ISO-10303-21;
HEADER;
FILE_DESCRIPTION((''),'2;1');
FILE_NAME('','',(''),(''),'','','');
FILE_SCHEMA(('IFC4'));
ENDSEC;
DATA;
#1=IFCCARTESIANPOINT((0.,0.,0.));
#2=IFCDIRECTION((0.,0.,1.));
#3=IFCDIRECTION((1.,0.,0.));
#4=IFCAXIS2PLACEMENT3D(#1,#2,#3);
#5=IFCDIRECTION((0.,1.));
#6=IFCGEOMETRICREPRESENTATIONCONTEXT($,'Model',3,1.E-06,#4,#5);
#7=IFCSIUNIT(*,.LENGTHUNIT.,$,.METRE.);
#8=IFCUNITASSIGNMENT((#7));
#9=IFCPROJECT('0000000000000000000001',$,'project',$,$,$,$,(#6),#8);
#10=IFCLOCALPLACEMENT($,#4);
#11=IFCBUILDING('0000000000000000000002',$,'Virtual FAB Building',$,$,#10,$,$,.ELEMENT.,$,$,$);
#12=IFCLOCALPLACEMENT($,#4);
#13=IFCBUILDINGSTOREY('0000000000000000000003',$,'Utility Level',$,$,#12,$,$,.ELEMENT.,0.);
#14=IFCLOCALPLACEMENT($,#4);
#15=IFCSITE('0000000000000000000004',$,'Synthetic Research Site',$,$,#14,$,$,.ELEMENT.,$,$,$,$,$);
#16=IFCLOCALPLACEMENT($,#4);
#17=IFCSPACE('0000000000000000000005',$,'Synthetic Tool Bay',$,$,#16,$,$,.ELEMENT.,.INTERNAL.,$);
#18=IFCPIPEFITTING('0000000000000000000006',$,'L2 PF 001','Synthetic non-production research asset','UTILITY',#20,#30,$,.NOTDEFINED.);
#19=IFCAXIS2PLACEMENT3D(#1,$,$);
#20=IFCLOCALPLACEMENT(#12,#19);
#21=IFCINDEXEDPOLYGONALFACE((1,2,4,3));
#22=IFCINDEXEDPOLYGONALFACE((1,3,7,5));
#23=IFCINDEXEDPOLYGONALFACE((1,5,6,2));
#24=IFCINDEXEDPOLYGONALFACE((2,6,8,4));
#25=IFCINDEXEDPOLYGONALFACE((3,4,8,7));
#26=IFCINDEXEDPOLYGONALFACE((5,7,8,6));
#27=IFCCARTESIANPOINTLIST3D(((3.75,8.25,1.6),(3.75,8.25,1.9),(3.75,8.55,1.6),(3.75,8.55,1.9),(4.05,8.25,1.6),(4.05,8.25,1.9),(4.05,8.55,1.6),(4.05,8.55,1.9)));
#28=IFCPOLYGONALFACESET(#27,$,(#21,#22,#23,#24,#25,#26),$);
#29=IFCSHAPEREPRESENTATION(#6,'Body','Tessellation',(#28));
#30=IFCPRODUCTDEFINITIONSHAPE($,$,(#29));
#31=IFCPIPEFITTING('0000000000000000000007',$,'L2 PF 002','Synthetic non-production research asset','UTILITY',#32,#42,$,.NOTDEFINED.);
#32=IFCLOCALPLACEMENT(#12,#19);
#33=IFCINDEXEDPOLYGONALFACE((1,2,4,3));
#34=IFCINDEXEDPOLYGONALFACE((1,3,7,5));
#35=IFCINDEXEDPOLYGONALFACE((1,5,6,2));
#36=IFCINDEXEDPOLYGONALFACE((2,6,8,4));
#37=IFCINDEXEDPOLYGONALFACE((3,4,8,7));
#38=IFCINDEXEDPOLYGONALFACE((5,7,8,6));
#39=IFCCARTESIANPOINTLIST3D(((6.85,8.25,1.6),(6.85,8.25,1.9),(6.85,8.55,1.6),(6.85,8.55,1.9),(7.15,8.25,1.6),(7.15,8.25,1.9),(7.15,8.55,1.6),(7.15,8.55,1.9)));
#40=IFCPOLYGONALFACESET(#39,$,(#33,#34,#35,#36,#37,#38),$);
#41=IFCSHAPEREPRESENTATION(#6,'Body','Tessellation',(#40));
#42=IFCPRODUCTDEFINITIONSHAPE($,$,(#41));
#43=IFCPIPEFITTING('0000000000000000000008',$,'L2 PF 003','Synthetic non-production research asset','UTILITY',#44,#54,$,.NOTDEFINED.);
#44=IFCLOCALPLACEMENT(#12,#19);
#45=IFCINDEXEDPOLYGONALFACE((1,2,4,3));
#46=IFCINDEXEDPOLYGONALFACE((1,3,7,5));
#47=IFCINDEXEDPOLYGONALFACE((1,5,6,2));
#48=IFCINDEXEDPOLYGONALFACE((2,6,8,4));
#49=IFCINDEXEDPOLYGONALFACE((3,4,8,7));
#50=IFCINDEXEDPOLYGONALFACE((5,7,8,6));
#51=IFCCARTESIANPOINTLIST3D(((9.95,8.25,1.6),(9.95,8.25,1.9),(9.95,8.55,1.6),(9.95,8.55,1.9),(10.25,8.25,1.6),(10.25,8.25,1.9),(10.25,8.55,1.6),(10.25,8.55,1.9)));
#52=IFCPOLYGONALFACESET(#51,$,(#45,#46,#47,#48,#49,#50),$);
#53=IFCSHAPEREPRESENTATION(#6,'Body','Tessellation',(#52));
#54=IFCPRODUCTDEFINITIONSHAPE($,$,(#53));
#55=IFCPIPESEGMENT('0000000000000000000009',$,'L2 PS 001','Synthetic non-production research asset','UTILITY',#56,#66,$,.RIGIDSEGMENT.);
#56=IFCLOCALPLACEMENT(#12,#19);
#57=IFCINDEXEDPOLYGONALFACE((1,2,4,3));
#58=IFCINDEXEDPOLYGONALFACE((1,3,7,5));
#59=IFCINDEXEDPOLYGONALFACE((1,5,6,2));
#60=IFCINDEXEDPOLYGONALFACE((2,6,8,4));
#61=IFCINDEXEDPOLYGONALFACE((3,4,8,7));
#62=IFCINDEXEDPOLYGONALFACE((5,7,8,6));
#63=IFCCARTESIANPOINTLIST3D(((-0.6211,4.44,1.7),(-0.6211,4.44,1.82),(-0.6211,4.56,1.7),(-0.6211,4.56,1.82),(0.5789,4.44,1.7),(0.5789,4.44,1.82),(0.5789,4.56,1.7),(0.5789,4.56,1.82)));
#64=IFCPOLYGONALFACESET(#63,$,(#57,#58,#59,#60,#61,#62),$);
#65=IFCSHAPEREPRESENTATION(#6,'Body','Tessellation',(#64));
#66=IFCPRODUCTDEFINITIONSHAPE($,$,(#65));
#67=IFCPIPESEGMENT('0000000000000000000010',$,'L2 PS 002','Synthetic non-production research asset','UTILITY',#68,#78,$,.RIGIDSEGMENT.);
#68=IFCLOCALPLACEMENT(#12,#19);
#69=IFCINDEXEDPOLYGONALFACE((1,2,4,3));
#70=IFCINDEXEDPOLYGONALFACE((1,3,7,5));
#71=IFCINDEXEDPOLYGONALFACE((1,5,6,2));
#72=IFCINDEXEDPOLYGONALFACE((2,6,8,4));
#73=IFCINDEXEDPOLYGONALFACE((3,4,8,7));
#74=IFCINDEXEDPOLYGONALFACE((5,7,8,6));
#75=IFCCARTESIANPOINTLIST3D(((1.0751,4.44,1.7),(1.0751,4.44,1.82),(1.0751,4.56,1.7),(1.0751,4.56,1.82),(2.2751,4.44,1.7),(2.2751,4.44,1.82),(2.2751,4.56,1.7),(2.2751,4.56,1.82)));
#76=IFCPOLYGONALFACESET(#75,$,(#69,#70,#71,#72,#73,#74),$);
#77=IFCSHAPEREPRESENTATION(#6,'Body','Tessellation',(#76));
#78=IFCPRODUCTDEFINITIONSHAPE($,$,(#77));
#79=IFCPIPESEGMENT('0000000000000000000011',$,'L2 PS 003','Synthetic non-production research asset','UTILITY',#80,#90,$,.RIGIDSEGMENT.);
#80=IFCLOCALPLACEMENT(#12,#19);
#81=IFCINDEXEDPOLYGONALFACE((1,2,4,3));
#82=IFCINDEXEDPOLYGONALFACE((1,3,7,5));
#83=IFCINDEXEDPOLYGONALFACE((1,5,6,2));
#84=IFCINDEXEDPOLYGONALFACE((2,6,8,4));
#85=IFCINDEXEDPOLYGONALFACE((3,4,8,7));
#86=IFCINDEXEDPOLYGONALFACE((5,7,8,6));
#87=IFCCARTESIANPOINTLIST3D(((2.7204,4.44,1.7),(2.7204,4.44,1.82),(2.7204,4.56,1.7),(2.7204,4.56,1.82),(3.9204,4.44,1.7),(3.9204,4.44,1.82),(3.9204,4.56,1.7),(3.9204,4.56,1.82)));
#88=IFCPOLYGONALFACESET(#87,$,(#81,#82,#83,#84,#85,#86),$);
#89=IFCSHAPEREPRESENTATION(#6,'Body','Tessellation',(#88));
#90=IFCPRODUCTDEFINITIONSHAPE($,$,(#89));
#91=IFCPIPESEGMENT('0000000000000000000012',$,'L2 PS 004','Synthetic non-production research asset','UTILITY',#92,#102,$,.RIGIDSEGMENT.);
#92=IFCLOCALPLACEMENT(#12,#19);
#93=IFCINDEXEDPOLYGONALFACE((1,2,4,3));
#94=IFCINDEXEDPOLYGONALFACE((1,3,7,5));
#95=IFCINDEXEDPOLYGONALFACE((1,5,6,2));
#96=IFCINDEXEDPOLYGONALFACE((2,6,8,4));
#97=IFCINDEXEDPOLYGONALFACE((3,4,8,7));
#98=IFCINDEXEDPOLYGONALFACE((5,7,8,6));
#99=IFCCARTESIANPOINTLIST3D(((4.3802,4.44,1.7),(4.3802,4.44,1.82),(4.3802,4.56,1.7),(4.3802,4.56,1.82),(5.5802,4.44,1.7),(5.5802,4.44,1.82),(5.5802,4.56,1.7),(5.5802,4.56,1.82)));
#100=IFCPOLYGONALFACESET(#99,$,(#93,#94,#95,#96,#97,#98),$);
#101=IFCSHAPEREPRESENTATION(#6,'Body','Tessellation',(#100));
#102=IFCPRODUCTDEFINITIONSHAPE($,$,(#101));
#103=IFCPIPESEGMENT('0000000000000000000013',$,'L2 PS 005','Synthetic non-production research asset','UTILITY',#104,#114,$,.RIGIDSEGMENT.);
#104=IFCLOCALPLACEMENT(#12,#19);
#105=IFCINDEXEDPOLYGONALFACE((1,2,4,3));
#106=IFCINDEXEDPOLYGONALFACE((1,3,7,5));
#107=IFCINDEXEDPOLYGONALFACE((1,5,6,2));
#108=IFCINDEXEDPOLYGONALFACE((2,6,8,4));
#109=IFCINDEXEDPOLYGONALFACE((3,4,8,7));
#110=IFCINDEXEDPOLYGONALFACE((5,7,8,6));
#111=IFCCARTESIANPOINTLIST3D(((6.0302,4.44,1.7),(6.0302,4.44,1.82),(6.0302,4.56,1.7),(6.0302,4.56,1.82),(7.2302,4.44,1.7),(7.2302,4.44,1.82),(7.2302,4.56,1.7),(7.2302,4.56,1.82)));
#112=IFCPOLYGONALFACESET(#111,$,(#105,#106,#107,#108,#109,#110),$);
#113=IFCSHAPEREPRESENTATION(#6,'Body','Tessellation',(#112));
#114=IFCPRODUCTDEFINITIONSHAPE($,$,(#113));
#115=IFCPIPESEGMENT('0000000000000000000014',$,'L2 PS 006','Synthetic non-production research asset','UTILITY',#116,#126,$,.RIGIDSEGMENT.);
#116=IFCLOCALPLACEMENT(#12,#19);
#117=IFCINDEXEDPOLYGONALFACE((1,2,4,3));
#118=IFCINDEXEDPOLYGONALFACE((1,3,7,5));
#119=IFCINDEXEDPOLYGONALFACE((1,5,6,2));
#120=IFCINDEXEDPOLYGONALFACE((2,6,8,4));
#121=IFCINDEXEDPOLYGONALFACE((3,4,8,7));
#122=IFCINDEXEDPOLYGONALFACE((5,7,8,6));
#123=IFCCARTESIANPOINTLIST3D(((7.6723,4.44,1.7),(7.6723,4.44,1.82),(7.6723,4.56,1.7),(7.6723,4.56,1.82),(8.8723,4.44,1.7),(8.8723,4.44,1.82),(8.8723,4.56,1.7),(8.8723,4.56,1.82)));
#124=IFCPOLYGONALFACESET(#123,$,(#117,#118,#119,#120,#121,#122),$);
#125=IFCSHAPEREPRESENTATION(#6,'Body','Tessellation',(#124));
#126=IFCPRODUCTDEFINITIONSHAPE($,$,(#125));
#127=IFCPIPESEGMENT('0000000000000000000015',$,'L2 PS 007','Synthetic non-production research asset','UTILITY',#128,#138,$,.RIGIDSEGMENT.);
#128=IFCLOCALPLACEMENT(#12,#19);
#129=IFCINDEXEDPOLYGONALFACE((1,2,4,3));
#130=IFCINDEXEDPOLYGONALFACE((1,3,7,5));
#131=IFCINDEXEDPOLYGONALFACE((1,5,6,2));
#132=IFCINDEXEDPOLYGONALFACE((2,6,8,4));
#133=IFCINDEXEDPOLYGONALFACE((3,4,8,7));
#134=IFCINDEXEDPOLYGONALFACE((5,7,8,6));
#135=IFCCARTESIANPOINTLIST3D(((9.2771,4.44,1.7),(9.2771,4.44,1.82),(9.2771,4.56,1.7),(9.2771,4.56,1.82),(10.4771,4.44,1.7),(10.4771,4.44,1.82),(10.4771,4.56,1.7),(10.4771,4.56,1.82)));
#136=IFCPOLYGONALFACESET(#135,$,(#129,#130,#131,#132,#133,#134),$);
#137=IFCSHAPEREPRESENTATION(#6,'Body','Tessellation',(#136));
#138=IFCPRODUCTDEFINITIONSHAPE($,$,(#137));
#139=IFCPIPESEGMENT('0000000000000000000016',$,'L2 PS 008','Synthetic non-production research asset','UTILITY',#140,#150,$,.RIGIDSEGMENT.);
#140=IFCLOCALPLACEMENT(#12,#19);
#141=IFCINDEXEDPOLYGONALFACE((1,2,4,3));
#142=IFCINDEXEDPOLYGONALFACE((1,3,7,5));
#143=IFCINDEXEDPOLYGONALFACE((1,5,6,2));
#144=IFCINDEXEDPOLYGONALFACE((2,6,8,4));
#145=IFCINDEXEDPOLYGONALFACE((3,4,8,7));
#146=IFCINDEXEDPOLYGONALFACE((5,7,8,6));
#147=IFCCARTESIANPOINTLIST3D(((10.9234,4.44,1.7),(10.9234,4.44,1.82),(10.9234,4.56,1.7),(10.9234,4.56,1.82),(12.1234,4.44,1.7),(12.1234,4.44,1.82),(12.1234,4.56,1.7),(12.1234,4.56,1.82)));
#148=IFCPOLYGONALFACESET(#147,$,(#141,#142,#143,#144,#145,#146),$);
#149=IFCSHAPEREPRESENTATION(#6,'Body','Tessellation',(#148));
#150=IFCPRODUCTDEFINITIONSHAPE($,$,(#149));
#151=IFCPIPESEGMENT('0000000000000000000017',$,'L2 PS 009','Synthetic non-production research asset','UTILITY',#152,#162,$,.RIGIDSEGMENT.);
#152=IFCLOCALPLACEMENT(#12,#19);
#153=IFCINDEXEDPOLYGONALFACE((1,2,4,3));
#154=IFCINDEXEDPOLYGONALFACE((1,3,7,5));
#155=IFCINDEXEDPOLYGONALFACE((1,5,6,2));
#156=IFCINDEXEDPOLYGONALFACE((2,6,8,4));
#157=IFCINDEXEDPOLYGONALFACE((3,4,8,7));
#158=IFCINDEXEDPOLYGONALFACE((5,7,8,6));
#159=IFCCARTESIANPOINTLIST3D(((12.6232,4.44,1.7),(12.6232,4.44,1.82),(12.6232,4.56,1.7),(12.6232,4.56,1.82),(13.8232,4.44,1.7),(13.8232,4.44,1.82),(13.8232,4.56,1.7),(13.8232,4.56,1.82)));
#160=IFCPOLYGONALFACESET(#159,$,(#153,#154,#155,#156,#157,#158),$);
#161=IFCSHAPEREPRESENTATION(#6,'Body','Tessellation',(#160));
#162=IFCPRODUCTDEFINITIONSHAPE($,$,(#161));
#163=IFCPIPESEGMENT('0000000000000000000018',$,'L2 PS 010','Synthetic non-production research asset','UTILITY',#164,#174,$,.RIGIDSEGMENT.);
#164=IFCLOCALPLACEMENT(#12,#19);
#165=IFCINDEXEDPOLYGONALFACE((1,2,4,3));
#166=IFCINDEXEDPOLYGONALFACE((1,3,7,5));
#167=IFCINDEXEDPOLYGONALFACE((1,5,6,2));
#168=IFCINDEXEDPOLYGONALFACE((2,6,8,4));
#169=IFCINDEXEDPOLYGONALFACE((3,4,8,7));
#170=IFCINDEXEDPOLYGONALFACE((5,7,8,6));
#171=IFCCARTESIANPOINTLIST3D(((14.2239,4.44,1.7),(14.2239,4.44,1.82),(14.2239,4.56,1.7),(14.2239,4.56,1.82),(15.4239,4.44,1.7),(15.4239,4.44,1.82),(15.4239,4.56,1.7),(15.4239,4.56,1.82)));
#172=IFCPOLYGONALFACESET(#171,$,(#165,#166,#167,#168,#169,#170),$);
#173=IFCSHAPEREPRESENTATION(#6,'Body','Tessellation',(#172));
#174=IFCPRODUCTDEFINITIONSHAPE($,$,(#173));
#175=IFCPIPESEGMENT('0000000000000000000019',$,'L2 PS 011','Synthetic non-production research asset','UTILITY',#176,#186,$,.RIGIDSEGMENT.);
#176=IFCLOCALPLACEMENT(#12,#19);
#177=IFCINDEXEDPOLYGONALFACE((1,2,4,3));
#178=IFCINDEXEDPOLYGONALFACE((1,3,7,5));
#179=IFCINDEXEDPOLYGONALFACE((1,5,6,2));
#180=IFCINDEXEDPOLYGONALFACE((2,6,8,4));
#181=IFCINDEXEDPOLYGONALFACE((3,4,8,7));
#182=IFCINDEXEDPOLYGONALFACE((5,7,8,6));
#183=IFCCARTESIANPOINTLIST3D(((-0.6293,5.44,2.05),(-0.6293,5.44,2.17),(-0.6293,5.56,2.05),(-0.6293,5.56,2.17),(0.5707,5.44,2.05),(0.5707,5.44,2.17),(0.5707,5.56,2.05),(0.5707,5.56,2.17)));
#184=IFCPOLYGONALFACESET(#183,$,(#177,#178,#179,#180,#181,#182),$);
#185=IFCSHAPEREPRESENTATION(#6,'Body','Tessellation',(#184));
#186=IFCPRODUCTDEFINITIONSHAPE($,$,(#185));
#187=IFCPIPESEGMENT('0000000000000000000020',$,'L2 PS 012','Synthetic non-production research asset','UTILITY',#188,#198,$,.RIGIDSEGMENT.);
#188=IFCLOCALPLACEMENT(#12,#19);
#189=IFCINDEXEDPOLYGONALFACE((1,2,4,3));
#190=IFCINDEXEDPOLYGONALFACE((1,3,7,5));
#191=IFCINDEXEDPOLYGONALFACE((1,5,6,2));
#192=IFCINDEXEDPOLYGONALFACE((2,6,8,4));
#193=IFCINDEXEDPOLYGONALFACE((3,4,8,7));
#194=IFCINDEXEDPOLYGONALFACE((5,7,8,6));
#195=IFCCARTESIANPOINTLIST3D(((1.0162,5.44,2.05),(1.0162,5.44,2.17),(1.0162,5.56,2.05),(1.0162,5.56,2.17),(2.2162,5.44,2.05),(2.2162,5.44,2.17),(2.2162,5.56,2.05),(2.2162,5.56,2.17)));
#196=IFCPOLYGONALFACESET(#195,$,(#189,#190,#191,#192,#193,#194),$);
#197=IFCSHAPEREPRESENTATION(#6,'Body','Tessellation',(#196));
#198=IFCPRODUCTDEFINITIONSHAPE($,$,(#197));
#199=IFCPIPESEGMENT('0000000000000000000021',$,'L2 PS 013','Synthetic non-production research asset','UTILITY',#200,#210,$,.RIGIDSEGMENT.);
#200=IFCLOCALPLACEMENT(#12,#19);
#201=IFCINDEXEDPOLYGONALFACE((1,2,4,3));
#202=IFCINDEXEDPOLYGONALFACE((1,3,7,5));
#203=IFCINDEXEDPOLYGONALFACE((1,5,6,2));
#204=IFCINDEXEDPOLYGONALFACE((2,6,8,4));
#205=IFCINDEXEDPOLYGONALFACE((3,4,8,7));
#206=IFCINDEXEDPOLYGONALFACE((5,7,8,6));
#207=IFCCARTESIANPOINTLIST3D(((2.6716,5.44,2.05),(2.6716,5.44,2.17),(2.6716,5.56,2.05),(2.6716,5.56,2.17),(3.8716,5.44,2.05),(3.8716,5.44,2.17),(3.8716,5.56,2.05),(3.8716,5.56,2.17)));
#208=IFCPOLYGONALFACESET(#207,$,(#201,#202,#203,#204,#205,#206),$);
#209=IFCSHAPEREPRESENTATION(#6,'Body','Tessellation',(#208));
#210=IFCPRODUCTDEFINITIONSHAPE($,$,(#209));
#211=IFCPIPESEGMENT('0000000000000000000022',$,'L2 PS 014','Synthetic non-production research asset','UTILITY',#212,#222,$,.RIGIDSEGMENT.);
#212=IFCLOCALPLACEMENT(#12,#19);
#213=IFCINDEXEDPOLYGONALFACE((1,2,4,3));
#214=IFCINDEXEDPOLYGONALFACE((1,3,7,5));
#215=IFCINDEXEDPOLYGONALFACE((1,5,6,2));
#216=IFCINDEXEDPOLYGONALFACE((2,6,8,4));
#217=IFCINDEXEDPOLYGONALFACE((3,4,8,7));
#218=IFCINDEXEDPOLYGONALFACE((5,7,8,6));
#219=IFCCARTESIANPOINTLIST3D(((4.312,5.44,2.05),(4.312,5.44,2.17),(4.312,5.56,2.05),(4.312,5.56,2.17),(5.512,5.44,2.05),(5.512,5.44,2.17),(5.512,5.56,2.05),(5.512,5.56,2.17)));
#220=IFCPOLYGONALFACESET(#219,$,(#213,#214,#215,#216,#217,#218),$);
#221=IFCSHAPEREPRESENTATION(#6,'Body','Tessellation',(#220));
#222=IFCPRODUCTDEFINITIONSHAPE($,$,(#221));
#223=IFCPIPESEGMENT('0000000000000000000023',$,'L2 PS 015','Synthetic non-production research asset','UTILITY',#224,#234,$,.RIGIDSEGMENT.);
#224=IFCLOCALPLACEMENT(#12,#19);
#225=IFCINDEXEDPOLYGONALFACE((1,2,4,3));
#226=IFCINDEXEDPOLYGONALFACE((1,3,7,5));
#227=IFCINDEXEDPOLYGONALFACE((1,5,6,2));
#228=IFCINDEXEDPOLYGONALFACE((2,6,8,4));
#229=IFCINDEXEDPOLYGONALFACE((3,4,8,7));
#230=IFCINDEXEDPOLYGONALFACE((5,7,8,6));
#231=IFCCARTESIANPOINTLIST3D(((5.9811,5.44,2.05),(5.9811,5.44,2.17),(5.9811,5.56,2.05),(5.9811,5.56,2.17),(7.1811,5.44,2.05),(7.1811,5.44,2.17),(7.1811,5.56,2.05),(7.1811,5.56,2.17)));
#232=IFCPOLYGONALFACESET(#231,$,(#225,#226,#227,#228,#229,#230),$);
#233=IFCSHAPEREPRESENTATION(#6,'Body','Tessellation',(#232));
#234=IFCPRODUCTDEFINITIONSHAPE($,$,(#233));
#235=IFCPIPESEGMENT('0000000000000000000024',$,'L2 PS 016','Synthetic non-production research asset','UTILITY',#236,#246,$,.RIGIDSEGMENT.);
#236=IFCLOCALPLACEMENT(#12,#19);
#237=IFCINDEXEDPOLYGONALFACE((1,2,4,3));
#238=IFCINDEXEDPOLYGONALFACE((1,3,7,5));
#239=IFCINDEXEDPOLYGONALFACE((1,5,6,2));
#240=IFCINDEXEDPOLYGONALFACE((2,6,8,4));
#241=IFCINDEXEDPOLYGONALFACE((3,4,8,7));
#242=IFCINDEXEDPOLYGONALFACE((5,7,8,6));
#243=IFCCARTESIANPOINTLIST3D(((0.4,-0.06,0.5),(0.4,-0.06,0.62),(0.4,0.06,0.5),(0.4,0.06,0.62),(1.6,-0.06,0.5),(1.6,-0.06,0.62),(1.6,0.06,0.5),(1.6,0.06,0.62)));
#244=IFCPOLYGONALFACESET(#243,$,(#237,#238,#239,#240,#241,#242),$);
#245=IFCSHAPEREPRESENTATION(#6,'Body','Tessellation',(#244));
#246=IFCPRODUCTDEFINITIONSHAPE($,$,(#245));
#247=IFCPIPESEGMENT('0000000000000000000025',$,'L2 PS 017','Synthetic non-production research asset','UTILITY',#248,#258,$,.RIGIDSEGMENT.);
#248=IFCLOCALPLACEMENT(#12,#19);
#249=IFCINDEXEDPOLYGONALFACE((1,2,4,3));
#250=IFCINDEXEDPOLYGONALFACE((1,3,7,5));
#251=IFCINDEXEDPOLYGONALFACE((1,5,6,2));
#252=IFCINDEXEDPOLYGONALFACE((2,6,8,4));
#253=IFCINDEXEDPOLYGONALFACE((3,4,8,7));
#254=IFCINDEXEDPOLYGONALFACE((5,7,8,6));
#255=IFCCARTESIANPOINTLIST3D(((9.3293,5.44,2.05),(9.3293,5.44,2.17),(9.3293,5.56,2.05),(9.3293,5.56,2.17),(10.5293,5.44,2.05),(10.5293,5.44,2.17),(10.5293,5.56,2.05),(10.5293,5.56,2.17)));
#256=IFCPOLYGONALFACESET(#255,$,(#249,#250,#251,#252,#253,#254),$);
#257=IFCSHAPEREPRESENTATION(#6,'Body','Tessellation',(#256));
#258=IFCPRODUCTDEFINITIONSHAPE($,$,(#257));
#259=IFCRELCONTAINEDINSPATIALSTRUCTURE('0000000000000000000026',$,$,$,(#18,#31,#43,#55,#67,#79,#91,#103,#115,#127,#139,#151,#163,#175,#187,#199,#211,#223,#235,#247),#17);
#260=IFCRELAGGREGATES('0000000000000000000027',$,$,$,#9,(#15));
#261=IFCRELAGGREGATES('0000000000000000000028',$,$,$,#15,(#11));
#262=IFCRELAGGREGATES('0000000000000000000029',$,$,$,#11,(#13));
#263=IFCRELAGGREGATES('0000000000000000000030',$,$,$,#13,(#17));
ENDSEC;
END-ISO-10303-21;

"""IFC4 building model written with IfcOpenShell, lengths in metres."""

from ifc_helpers import new_model, si_unit, direction, frame, origin_with_axes, origin_2d_with_axis, place, context, project, spatial, rectangle, extrude, element, save


model = new_model("IFC4")

# Units and contexts
model_context = context("Model", 3, precision=1e-06, world=origin_with_axes(), true_north=direction((0.0, 1.0)))
ifc_project = project(units=[si_unit("LENGTHUNIT", "METRE")], contexts=[model_context])

# Site, building, storey, space
site_placement = place(None, origin_with_axes())
site = spatial("IfcSite", under=ifc_project, at=site_placement, Name="Synthetic Research Site", CompositionType="ELEMENT")
building_placement = place(None, origin_with_axes())
building = spatial("IfcBuilding", under=site, at=building_placement, Name="Virtual FAB Building", CompositionType="ELEMENT")
storey_placement = place(None, origin_with_axes())
storey = spatial("IfcBuildingStorey", under=building, at=storey_placement, Name="Utility Level", CompositionType="ELEMENT", Elevation=0.0)
space_placement = place(None, origin_with_axes())
space = spatial("IfcSpace", under=storey, at=space_placement, Name="Synthetic Tool Bay", CompositionType="ELEMENT", PredefinedType="INTERNAL")

# Pipe fittings
for number, where, z_axis, x_axis, name in (
    (1, (3.9, 8.4, 1.6), (0.0, 0.0, 1.0), (1.0, 0.0, 0.0), "L2 PF 001"),
    (2, (7.0, 8.4, 1.6), (0.0, 0.0, 1.0), (1.0, 0.0, 0.0), "L2 PF 002"),
    (3, (10.1, 8.4, 1.6), (0.0, 0.0, 1.0), (1.0, 0.0, 0.0), "L2 PF 003"),
):
    element("IfcPipeFitting", number, at=place(None, frame(where, z_axis=z_axis, x_axis=x_axis)), inside=space, Name=name, Description="Synthetic non-production research asset", ObjectType="UTILITY", PredefinedType="NOTDEFINED", context=model_context, shape_type="SweptSolid", body=[
        extrude(rectangle(XDim=0.3, YDim=0.3, at=origin_2d_with_axis()), origin_with_axes(), (0.0, 0.0, 1.0), 0.3),
    ])

# Pipe segments
for number, where, z_axis, x_axis, name in (
    (4, (-0.0211, 4.5, 1.7), (0.0, 0.0, 1.0), (1.0, 0.0, 0.0), "L2 PS 001"),
    (5, (1.6751, 4.5, 1.7), (0.0, 0.0, 1.0), (1.0, 0.0, 0.0), "L2 PS 002"),
    (6, (3.3204, 4.5, 1.7), (0.0, 0.0, 1.0), (1.0, 0.0, 0.0), "L2 PS 003"),
    (7, (4.9802, 4.5, 1.7), (0.0, 0.0, 1.0), (1.0, 0.0, 0.0), "L2 PS 004"),
    (8, (6.6302, 4.5, 1.7), (0.0, 0.0, 1.0), (1.0, 0.0, 0.0), "L2 PS 005"),
    (9, (8.2723, 4.5, 1.7), (0.0, 0.0, 1.0), (1.0, 0.0, 0.0), "L2 PS 006"),
    (10, (9.8771, 4.5, 1.7), (0.0, 0.0, 1.0), (1.0, 0.0, 0.0), "L2 PS 007"),
    (11, (11.5234, 4.5, 1.7), (0.0, 0.0, 1.0), (1.0, 0.0, 0.0), "L2 PS 008"),
    (12, (13.2232, 4.5, 1.7), (0.0, 0.0, 1.0), (1.0, 0.0, 0.0), "L2 PS 009"),
    (13, (14.8239, 4.5, 1.7), (0.0, 0.0, 1.0), (1.0, 0.0, 0.0), "L2 PS 010"),
    (14, (-0.0293, 5.5, 2.05), (0.0, 0.0, 1.0), (1.0, 0.0, 0.0), "L2 PS 011"),
    (15, (1.6162, 5.5, 2.05), (0.0, 0.0, 1.0), (1.0, 0.0, 0.0), "L2 PS 012"),
    (16, (3.2716, 5.5, 2.05), (0.0, 0.0, 1.0), (1.0, 0.0, 0.0), "L2 PS 013"),
    (17, (4.912, 5.5, 2.05), (0.0, 0.0, 1.0), (1.0, 0.0, 0.0), "L2 PS 014"),
    (18, (6.5811, 5.5, 2.05), (0.0, 0.0, 1.0), (1.0, 0.0, 0.0), "L2 PS 015"),
    (19, (1.0, 0.0, 0.5), (0.0, 0.0, 1.0), (1.0, 0.0, 0.0), "L2 PS 016"),
    (20, (9.9293, 5.5, 2.05), (0.0, 0.0, 1.0), (1.0, 0.0, 0.0), "L2 PS 017"),
):
    element("IfcPipeSegment", number, at=place(None, frame(where, z_axis=z_axis, x_axis=x_axis)), inside=space, Name=name, Description="Synthetic non-production research asset", ObjectType="UTILITY", PredefinedType="RIGIDSEGMENT", context=model_context, shape_type="SweptSolid", body=[
        extrude(rectangle(XDim=1.2, YDim=0.12, at=origin_2d_with_axis()), origin_with_axes(), (0.0, 0.0, 1.0), 0.12),
    ])

save(model, "model.ifc")
